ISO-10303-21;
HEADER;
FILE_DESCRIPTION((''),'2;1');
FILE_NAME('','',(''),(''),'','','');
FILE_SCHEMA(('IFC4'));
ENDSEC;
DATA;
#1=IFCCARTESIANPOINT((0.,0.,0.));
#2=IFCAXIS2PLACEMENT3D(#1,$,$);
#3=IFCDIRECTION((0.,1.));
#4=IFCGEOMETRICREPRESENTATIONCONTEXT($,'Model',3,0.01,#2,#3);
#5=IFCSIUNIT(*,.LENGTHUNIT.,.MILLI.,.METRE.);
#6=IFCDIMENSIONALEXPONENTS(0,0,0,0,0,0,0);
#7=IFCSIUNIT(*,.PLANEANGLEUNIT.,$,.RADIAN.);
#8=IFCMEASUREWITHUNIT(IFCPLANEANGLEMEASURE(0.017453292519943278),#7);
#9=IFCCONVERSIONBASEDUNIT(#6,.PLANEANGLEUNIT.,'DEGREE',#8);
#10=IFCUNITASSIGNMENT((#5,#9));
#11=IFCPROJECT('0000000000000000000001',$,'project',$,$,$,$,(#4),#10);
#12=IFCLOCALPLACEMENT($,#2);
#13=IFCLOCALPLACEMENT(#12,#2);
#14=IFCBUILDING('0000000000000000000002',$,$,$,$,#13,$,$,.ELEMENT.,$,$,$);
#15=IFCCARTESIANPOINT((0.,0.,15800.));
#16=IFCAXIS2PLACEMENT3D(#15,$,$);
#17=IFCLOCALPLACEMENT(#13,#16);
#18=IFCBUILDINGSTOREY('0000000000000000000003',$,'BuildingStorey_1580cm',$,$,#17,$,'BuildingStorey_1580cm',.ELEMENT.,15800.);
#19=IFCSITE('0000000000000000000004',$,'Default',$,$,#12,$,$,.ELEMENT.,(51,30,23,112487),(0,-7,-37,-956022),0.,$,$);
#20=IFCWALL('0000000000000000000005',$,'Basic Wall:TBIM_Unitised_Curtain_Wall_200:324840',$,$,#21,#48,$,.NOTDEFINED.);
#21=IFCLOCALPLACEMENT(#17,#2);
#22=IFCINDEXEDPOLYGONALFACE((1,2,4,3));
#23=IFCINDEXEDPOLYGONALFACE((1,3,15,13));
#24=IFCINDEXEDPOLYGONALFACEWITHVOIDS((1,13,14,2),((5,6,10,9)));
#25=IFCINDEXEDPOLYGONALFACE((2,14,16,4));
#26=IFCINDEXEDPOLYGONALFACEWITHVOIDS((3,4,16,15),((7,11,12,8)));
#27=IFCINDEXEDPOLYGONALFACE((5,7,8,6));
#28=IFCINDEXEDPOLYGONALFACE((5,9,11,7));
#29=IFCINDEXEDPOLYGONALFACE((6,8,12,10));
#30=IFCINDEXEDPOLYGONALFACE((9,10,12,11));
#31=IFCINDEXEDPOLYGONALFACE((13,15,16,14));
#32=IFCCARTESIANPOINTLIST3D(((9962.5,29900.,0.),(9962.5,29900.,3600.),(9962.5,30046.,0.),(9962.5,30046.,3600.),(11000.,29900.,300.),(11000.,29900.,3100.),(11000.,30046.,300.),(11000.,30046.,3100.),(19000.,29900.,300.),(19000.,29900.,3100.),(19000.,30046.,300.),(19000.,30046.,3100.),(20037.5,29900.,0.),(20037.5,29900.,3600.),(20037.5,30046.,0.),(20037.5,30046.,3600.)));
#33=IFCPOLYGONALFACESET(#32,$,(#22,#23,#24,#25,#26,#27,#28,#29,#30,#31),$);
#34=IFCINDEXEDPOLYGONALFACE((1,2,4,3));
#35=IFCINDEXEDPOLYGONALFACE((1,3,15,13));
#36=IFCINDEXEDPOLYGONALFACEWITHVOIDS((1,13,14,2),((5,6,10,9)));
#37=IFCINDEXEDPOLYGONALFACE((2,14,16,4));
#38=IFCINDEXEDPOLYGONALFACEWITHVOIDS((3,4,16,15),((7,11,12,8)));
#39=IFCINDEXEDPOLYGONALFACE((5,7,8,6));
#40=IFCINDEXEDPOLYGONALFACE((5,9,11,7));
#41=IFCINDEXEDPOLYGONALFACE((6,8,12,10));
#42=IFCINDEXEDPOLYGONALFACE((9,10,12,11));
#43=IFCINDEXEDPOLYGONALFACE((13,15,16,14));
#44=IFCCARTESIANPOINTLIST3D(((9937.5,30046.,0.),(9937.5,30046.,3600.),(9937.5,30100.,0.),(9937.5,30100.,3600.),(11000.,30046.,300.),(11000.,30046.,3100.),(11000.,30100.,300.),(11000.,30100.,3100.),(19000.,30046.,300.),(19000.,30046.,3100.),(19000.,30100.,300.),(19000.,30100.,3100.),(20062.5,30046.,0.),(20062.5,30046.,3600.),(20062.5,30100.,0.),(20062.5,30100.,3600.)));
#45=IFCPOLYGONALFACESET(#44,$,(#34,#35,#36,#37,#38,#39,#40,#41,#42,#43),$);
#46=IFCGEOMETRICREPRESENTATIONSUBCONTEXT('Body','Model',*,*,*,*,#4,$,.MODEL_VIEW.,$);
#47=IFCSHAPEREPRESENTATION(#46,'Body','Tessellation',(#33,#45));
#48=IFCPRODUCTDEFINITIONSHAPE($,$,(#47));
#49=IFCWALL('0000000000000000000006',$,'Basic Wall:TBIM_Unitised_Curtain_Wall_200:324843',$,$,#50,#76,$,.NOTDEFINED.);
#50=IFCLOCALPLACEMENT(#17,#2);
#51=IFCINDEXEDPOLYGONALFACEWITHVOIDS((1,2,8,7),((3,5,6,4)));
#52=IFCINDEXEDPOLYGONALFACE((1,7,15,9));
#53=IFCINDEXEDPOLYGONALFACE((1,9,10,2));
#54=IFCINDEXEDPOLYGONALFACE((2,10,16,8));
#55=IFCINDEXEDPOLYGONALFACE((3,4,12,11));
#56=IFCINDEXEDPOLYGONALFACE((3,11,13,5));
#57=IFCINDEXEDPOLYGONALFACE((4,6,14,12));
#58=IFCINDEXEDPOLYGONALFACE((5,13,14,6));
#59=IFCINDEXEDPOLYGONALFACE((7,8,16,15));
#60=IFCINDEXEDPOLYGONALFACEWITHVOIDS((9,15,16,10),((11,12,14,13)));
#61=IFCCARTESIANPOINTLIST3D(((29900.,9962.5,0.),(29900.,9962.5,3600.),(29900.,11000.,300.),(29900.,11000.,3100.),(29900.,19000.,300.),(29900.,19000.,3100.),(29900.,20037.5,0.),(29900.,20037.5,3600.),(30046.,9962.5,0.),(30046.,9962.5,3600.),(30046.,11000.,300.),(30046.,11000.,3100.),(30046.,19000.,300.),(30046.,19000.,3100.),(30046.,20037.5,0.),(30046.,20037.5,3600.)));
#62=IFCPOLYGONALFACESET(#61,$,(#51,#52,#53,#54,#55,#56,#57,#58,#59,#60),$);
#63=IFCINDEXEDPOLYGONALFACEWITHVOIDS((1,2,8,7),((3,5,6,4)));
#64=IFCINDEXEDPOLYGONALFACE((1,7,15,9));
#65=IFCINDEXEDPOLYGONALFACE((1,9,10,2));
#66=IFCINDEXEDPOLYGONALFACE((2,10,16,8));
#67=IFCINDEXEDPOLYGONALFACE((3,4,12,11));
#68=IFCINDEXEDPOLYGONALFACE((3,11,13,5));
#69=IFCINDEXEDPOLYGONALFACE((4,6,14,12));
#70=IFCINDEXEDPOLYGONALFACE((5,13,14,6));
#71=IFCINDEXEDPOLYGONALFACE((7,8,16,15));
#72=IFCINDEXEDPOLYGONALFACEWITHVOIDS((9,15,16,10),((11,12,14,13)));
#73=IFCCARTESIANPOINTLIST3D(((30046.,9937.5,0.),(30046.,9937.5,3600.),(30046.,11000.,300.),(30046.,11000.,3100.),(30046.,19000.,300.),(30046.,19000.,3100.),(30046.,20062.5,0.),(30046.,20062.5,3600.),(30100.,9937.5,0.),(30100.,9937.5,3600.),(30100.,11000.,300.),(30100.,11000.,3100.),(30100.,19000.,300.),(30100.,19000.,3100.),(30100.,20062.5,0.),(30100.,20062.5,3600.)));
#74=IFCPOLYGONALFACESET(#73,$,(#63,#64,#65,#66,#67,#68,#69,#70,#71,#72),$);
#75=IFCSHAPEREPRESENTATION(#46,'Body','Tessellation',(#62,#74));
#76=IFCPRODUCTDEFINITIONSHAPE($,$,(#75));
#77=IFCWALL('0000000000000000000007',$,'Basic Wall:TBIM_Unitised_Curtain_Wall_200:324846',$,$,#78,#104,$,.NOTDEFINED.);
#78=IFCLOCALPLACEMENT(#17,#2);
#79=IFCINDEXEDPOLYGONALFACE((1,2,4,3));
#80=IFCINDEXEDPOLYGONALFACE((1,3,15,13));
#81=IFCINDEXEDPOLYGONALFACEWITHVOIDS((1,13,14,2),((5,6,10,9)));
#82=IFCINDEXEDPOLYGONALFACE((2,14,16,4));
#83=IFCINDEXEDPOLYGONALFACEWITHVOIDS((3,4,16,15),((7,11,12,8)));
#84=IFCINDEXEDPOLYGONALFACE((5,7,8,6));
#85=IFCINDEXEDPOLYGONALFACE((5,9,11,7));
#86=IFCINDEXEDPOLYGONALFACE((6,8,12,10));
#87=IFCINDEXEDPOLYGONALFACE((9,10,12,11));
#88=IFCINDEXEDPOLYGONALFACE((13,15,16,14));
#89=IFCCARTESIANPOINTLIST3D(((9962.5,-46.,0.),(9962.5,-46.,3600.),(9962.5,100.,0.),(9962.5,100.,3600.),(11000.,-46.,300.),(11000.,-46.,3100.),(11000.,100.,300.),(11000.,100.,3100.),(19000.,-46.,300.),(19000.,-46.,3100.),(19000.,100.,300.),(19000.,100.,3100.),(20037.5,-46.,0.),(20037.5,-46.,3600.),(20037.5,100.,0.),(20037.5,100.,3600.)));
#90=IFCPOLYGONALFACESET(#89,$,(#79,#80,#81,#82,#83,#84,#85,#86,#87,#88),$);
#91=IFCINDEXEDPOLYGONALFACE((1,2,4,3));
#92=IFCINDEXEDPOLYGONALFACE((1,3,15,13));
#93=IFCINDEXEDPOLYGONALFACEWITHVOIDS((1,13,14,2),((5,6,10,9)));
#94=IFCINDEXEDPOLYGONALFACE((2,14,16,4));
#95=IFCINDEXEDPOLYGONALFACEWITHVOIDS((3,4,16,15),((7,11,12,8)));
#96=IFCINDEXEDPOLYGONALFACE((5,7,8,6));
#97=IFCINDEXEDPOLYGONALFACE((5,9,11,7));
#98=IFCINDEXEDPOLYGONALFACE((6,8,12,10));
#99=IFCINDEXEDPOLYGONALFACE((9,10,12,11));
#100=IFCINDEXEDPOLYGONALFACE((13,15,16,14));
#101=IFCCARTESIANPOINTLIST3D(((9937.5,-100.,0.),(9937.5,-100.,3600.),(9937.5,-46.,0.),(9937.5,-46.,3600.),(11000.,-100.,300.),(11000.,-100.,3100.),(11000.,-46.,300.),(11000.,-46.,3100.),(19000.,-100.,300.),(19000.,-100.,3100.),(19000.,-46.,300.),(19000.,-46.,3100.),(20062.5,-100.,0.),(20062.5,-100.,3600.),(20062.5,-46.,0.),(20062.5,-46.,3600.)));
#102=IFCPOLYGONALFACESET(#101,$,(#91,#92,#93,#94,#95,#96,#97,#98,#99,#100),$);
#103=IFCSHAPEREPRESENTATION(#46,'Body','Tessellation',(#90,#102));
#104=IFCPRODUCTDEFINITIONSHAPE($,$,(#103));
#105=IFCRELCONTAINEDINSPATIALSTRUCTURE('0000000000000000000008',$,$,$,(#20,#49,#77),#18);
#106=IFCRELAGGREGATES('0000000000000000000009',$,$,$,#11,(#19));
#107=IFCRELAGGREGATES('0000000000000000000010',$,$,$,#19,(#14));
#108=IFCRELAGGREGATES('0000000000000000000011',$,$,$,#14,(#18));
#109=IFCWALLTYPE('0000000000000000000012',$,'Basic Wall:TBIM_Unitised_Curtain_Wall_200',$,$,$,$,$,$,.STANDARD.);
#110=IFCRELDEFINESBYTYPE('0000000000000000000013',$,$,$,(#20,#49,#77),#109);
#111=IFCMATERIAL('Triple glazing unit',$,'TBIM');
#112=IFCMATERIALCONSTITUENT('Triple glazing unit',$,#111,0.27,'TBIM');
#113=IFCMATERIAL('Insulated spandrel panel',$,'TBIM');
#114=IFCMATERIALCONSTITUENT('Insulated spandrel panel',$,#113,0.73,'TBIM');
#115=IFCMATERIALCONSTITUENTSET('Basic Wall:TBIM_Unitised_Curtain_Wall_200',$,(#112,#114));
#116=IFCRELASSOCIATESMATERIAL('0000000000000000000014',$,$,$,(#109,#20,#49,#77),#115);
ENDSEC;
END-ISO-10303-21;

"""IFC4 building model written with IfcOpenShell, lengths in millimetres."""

from ifc_helpers import new_model, entity, si_unit, converted_unit, direction, frame, origin, place, context, subcontext, project, spatial, indexed_curve, outline, extrude, material, constituent, constituent_set, type_object, element, save


model = new_model("IFC4")

# Units and contexts
model_context = context("Model", 3, precision=0.01, world=origin(), true_north=direction((0.0, 1.0)))
body_context = subcontext(model_context, "Body", "Model", "MODEL_VIEW")
ifc_project = project(units=[si_unit("LENGTHUNIT", "METRE", prefix="MILLI"), converted_unit("PLANEANGLEUNIT", "DEGREE", entity("IfcPlaneAngleMeasure", 0.017453292519943278), si_unit("PLANEANGLEUNIT", "RADIAN"), dimensions=[0, 0, 0, 0, 0, 0, 0])], contexts=[model_context])

# Site, building, storey
site_placement = place(None, origin())
site = spatial("IfcSite", under=ifc_project, at=site_placement, Name="Default", CompositionType="ELEMENT", RefLatitude=(51, 30, 23, 112487), RefLongitude=(0, -7, -37, -956022), RefElevation=0.0)
building_placement = place(site_placement, origin())
building = spatial("IfcBuilding", under=site, at=building_placement, CompositionType="ELEMENT")
storey_placement = place(building_placement, frame((0.0, 0.0, 15800.0)))
storey = spatial("IfcBuildingStorey", under=building, at=storey_placement, Name="BuildingStorey_1580cm", LongName="BuildingStorey_1580cm", CompositionType="ELEMENT", Elevation=15800.0)

# Walls, openings
ifc_material_1 = material(Name="Triple glazing unit", Category="TBIM")
ifc_constituent_1 = constituent(ifc_material_1, Name="Triple glazing unit", Category="TBIM", fraction=0.27)
ifc_material_2 = material(Name="Insulated spandrel panel", Category="TBIM")
ifc_constituent_2 = constituent(ifc_material_2, Name="Insulated spandrel panel", Category="TBIM", fraction=0.73)
ifc_constituent_set_1 = constituent_set(constituents=[ifc_constituent_1, ifc_constituent_2], Name="Basic Wall:TBIM_Unitised_Curtain_Wall_200")
wall_type_1 = type_object("IfcWallType", Name="Basic Wall:TBIM_Unitised_Curtain_Wall_200", PredefinedType="STANDARD", material=ifc_constituent_set_1)
wall_1_placement = place(storey_placement, frame((9937.5, 30000.0, 0.0)))
wall_1 = element("IfcWall", 1, at=wall_1_placement, inside=storey, type_object=wall_type_1, material=ifc_constituent_set_1, Name="Basic Wall:TBIM_Unitised_Curtain_Wall_200:324840", PredefinedType="NOTDEFINED", context=body_context, shape_type="SweptSolid", body=[
    extrude(outline(indexed_curve([(-1800.0, -5037.5), (1800.0, -5037.5), (1800.0, -4937.5), (1800.0, 4937.5), (1800.0, 5037.5), (-1800.0, 5037.5), (-1800.0, 4937.5), (-1800.0, -4937.5), (-1800.0, -5037.5)], self_intersect=False), holes=[indexed_curve([(1300.0, -4000.0), (-1500.0, -4000.0), (-1500.0, 4000.0), (1300.0, 4000.0), (1300.0, -4000.0)], self_intersect=False)]), frame((5062.5, -100.0, 1800.0), z_axis=(0.0, 1.0, 0.0), x_axis=(0.0, 0.0, 1.0)), (0.0, 0.0, 1.0), 146.0),
    extrude(outline(indexed_curve([(-1800.0, -5062.5), (1800.0, -5062.5), (1800.0, 5062.5), (-1800.0, 5062.5), (-1800.0, -5062.5)], self_intersect=False), holes=[indexed_curve([(-1500.0, -4000.0), (-1500.0, 4000.0), (1300.0, 4000.0), (1300.0, -4000.0), (-1500.0, -4000.0)], self_intersect=False)]), frame((5062.5, 46.0, 1800.0), z_axis=(0.0, 1.0, 0.0), x_axis=(0.0, 0.0, 1.0)), (0.0, 0.0, 1.0), 54.0),
])
opening_1_placement = place(wall_1_placement, frame((1062.5, -100.0, 300.0)))
element("IfcOpeningElement", 2, at=opening_1_placement, cuts=wall_1, PredefinedType="OPENING", context=body_context, shape_type="SweptSolid", body=[
    extrude(outline(indexed_curve([(2800.0, 0.0), (2800.0, 8000.0), (0.0, 8000.0), (0.0, 0.0), (2800.0, 0.0)], self_intersect=False)), frame((0.0, 0.0, 0.0), z_axis=(0.0, 1.0, 0.0), x_axis=(0.0, 0.0, 1.0)), (0.0, 0.0, 1.0), 200.0),
])
wall_2_placement = place(storey_placement, frame((30000.0, 9937.5, 0.0), z_axis=(0.0, 0.0, 1.0), x_axis=(0.0, 1.0, 0.0)))
wall_2 = element("IfcWall", 3, at=wall_2_placement, inside=storey, type_object=wall_type_1, material=ifc_constituent_set_1, Name="Basic Wall:TBIM_Unitised_Curtain_Wall_200:324843", PredefinedType="NOTDEFINED", context=body_context, shape_type="SweptSolid", body=[
    extrude(outline(indexed_curve([(-5037.5, -1800.0), (-4937.5, -1800.0), (4937.5, -1800.0), (5037.5, -1800.0), (5037.5, 1800.0), (4937.5, 1800.0), (-4937.5, 1800.0), (-5037.5, 1800.0), (-5037.5, -1800.0)], self_intersect=False), holes=[indexed_curve([(-4000.0, 1300.0), (4000.0, 1300.0), (4000.0, -1500.0), (-4000.0, -1500.0), (-4000.0, 1300.0)], self_intersect=False)]), frame((5062.5, 100.0, 1800.0), z_axis=(0.0, -1.0, 0.0), x_axis=(1.0, 0.0, 0.0)), (0.0, 0.0, 1.0), 146.0),
    extrude(outline(indexed_curve([(-1800.0, -5062.5), (1800.0, -5062.5), (1800.0, 5062.5), (-1800.0, 5062.5), (-1800.0, -5062.5)], self_intersect=False), holes=[indexed_curve([(1300.0, 4000.0), (1300.0, -4000.0), (-1500.0, -4000.0), (-1500.0, 4000.0), (1300.0, 4000.0)], self_intersect=False)]), frame((5062.5, -46.0, 1800.0), z_axis=(0.0, -1.0, 0.0), x_axis=(0.0, 0.0, 1.0)), (0.0, 0.0, 1.0), 54.0),
])
opening_2_placement = place(wall_2_placement, frame((1062.5, -100.0, 300.0)))
element("IfcOpeningElement", 4, at=opening_2_placement, cuts=wall_2, PredefinedType="OPENING", context=body_context, shape_type="SweptSolid", body=[
    extrude(outline(indexed_curve([(2800.0, 0.0), (2800.0, 8000.0), (0.0, 8000.0), (0.0, 0.0), (2800.0, 0.0)], self_intersect=False)), frame((0.0, 0.0, 0.0), z_axis=(0.0, 1.0, 0.0), x_axis=(0.0, 0.0, 1.0)), (0.0, 0.0, 1.0), 200.0),
])
wall_3_placement = place(storey_placement, frame((9937.5, 0.0, 0.0)))
wall_3 = element("IfcWall", 5, at=wall_3_placement, inside=storey, type_object=wall_type_1, material=ifc_constituent_set_1, Name="Basic Wall:TBIM_Unitised_Curtain_Wall_200:324846", PredefinedType="NOTDEFINED", context=body_context, shape_type="SweptSolid", body=[
    extrude(outline(indexed_curve([(-1800.0, -5037.5), (1800.0, -5037.5), (1800.0, 5037.5), (-1800.0, 5037.5), (-1800.0, -5037.5)], self_intersect=False), holes=[indexed_curve([(-1500.0, -4000.0), (-1500.0, 4000.0), (1300.0, 4000.0), (1300.0, -4000.0), (-1500.0, -4000.0)], self_intersect=False)]), frame((5062.5, -46.0, 1800.0), z_axis=(0.0, 1.0, 0.0), x_axis=(0.0, 0.0, 1.0)), (0.0, 0.0, 1.0), 146.0),
    extrude(outline(indexed_curve([(-1800.0, -5062.5), (1800.0, -5062.5), (1800.0, 5062.5), (-1800.0, 5062.5), (-1800.0, -5062.5)], self_intersect=False), holes=[indexed_curve([(1300.0, -4000.0), (-1500.0, -4000.0), (-1500.0, 4000.0), (1300.0, 4000.0), (1300.0, -4000.0)], self_intersect=False)]), frame((5062.5, -100.0, 1800.0), z_axis=(0.0, 1.0, 0.0), x_axis=(0.0, 0.0, 1.0)), (0.0, 0.0, 1.0), 54.0),
])
opening_3_placement = place(wall_3_placement, frame((1062.5, -100.0, 300.0)))
element("IfcOpeningElement", 6, at=opening_3_placement, cuts=wall_3, PredefinedType="OPENING", context=body_context, shape_type="SweptSolid", body=[
    extrude(outline(indexed_curve([(2800.0, 0.0), (2800.0, 8000.0), (0.0, 8000.0), (0.0, 0.0), (2800.0, 0.0)], self_intersect=False)), frame((0.0, 0.0, 0.0), z_axis=(0.0, 1.0, 0.0), x_axis=(0.0, 0.0, 1.0)), (0.0, 0.0, 1.0), 200.0),
])

save(model, "model.ifc")
